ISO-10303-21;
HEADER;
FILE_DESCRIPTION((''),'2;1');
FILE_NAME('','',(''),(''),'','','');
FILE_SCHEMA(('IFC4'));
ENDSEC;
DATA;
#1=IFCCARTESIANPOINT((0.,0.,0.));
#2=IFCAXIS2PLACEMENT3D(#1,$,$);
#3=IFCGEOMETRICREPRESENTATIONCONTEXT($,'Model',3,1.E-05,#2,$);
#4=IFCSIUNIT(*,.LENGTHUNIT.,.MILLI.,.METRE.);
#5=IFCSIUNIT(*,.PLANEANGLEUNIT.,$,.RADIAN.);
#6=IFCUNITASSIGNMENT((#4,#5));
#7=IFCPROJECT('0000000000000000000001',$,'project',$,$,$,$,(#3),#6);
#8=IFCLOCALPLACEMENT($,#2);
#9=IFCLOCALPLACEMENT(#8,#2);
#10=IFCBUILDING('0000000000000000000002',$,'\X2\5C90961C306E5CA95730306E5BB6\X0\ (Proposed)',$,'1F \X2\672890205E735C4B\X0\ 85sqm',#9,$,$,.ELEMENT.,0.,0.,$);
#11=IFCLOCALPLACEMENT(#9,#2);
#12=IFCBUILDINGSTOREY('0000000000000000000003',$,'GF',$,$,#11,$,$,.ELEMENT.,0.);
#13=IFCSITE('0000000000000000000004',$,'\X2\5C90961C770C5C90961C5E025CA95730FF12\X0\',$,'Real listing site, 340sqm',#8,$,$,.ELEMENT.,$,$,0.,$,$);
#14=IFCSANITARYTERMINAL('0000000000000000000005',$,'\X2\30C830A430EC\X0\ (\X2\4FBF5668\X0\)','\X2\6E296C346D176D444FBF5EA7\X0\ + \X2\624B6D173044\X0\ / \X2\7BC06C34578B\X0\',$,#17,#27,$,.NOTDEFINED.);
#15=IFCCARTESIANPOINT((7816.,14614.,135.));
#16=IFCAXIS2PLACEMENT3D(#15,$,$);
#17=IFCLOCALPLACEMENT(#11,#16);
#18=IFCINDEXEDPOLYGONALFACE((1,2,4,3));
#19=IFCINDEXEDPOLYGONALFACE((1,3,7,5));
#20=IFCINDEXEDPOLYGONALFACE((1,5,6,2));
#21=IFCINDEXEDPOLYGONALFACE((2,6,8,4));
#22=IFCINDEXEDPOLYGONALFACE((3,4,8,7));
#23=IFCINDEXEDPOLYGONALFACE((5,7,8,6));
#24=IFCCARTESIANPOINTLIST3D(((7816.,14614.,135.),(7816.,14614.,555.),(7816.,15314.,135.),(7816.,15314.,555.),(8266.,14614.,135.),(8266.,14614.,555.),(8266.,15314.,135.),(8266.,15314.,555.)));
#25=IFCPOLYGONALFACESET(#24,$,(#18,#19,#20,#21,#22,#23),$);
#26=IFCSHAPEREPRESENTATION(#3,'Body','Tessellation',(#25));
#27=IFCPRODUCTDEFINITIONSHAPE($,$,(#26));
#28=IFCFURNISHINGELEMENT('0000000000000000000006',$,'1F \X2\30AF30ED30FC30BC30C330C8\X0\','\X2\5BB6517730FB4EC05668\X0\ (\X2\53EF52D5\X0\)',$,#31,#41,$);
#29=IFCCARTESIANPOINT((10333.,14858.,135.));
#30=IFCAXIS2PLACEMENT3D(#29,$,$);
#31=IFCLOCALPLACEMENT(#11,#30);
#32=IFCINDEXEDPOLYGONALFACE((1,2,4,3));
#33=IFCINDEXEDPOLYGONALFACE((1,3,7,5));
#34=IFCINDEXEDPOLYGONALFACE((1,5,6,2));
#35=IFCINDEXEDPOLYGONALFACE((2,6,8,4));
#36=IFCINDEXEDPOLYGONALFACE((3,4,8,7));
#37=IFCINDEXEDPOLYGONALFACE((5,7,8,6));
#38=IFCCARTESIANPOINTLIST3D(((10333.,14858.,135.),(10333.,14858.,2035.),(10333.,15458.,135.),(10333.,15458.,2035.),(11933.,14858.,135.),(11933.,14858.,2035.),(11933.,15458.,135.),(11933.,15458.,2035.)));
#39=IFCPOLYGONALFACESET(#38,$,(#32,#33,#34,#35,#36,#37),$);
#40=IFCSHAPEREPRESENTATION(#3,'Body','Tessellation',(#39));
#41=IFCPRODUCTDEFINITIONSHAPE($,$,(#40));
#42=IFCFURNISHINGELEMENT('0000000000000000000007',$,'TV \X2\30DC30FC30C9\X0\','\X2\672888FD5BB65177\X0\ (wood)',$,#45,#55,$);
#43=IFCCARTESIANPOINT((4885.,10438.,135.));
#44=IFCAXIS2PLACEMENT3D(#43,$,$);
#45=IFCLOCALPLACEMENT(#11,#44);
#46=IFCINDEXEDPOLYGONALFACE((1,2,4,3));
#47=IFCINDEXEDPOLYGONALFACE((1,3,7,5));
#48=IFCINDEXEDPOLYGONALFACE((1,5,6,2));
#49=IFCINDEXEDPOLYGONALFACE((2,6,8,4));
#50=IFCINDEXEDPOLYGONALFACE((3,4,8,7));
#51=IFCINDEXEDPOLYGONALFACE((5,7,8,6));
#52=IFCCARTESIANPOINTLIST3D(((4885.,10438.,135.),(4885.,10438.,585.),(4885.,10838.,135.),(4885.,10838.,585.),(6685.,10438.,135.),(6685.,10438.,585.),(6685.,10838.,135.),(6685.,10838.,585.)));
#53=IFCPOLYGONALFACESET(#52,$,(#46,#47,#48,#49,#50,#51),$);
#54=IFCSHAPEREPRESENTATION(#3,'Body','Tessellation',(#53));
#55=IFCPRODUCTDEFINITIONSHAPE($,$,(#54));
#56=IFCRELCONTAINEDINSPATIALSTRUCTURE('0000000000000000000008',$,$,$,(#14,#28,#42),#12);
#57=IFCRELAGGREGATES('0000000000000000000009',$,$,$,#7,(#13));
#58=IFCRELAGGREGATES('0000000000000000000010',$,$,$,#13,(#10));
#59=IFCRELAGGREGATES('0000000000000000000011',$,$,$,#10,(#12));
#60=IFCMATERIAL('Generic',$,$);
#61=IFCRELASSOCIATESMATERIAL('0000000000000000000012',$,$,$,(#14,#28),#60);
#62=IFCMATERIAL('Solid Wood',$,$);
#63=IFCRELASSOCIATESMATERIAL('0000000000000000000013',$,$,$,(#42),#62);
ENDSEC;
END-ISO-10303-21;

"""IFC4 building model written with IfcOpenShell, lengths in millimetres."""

from ifc_helpers import new_model, si_unit, frame, frame_2d, origin, place, context, project, spatial, rectangle, extrude, material, element, save


model = new_model("IFC4")

# Units and contexts
model_context = context("Model", 3, precision=1e-05, world=origin())
ifc_project = project(units=[si_unit("LENGTHUNIT", "METRE", prefix="MILLI"), si_unit("PLANEANGLEUNIT", "RADIAN")], contexts=[model_context])

# Site, building, storey
site_placement = place(None, origin())
site = spatial("IfcSite", under=ifc_project, at=site_placement, Name="岐阜県岐阜市岩地２", ObjectType="Real listing site, 340sqm", CompositionType="ELEMENT", RefElevation=0.0)
building_placement = place(site_placement, origin())
building = spatial("IfcBuilding", under=site, at=building_placement, Name="岐阜の岩地の家 (Proposed)", ObjectType="1F 木造平屋 85sqm", CompositionType="ELEMENT", ElevationOfRefHeight=0.0, ElevationOfTerrain=0.0)
storey_placement = place(building_placement, origin())
storey = spatial("IfcBuildingStorey", under=building, at=storey_placement, Name="GF", CompositionType="ELEMENT", Elevation=0.0)

# Shared definitions
ifc_material_1 = material(Name="Solid Wood")

# Sanitary terminal
ifc_material_2 = material(Name="Generic")
sanitary_terminal_1_placement = place(storey_placement, frame((7816.0, 14614.0, 135.0)))
element("IfcSanitaryTerminal", 1, at=sanitary_terminal_1_placement, inside=storey, material=ifc_material_2, Name="トイレ (便器)", Description="温水洗浄便座 + 手洗い / 節水型", PredefinedType="NOTDEFINED", context=model_context, shape_type="SweptSolid", body=[
    extrude(rectangle(XDim=450.0, YDim=700.0, at=frame_2d((225.0, 350.0))), frame((7816.0, 14614.0, 135.0)), (0.0, 0.0, 1.0), 420.0),
])

# Furnishing elements
furnishing_1_placement = place(storey_placement, frame((10333.0, 14858.0, 135.0)))
element("IfcFurnishingElement", 2, at=furnishing_1_placement, inside=storey, material=ifc_material_2, Name="1F クローゼット", Description="家具・什器 (可動)", context=model_context, shape_type="SweptSolid", body=[
    extrude(rectangle(XDim=1600.0, YDim=600.0, at=frame_2d((800.0, 300.0))), frame((10333.0, 14858.0, 135.0)), (0.0, 0.0, 1.0), 1900.0),
])
furnishing_2_placement = place(storey_placement, frame((4885.0, 10438.0, 135.0)))
element("IfcFurnishingElement", 3, at=furnishing_2_placement, inside=storey, material=ifc_material_1, Name="TV ボード", Description="木製家具 (wood)", context=model_context, shape_type="SweptSolid", body=[
    extrude(rectangle(XDim=1800.0, YDim=400.0, at=frame_2d((900.0, 200.0))), frame((4885.0, 10438.0, 135.0)), (0.0, 0.0, 1.0), 450.0),
])

save(model, "model.ifc")
